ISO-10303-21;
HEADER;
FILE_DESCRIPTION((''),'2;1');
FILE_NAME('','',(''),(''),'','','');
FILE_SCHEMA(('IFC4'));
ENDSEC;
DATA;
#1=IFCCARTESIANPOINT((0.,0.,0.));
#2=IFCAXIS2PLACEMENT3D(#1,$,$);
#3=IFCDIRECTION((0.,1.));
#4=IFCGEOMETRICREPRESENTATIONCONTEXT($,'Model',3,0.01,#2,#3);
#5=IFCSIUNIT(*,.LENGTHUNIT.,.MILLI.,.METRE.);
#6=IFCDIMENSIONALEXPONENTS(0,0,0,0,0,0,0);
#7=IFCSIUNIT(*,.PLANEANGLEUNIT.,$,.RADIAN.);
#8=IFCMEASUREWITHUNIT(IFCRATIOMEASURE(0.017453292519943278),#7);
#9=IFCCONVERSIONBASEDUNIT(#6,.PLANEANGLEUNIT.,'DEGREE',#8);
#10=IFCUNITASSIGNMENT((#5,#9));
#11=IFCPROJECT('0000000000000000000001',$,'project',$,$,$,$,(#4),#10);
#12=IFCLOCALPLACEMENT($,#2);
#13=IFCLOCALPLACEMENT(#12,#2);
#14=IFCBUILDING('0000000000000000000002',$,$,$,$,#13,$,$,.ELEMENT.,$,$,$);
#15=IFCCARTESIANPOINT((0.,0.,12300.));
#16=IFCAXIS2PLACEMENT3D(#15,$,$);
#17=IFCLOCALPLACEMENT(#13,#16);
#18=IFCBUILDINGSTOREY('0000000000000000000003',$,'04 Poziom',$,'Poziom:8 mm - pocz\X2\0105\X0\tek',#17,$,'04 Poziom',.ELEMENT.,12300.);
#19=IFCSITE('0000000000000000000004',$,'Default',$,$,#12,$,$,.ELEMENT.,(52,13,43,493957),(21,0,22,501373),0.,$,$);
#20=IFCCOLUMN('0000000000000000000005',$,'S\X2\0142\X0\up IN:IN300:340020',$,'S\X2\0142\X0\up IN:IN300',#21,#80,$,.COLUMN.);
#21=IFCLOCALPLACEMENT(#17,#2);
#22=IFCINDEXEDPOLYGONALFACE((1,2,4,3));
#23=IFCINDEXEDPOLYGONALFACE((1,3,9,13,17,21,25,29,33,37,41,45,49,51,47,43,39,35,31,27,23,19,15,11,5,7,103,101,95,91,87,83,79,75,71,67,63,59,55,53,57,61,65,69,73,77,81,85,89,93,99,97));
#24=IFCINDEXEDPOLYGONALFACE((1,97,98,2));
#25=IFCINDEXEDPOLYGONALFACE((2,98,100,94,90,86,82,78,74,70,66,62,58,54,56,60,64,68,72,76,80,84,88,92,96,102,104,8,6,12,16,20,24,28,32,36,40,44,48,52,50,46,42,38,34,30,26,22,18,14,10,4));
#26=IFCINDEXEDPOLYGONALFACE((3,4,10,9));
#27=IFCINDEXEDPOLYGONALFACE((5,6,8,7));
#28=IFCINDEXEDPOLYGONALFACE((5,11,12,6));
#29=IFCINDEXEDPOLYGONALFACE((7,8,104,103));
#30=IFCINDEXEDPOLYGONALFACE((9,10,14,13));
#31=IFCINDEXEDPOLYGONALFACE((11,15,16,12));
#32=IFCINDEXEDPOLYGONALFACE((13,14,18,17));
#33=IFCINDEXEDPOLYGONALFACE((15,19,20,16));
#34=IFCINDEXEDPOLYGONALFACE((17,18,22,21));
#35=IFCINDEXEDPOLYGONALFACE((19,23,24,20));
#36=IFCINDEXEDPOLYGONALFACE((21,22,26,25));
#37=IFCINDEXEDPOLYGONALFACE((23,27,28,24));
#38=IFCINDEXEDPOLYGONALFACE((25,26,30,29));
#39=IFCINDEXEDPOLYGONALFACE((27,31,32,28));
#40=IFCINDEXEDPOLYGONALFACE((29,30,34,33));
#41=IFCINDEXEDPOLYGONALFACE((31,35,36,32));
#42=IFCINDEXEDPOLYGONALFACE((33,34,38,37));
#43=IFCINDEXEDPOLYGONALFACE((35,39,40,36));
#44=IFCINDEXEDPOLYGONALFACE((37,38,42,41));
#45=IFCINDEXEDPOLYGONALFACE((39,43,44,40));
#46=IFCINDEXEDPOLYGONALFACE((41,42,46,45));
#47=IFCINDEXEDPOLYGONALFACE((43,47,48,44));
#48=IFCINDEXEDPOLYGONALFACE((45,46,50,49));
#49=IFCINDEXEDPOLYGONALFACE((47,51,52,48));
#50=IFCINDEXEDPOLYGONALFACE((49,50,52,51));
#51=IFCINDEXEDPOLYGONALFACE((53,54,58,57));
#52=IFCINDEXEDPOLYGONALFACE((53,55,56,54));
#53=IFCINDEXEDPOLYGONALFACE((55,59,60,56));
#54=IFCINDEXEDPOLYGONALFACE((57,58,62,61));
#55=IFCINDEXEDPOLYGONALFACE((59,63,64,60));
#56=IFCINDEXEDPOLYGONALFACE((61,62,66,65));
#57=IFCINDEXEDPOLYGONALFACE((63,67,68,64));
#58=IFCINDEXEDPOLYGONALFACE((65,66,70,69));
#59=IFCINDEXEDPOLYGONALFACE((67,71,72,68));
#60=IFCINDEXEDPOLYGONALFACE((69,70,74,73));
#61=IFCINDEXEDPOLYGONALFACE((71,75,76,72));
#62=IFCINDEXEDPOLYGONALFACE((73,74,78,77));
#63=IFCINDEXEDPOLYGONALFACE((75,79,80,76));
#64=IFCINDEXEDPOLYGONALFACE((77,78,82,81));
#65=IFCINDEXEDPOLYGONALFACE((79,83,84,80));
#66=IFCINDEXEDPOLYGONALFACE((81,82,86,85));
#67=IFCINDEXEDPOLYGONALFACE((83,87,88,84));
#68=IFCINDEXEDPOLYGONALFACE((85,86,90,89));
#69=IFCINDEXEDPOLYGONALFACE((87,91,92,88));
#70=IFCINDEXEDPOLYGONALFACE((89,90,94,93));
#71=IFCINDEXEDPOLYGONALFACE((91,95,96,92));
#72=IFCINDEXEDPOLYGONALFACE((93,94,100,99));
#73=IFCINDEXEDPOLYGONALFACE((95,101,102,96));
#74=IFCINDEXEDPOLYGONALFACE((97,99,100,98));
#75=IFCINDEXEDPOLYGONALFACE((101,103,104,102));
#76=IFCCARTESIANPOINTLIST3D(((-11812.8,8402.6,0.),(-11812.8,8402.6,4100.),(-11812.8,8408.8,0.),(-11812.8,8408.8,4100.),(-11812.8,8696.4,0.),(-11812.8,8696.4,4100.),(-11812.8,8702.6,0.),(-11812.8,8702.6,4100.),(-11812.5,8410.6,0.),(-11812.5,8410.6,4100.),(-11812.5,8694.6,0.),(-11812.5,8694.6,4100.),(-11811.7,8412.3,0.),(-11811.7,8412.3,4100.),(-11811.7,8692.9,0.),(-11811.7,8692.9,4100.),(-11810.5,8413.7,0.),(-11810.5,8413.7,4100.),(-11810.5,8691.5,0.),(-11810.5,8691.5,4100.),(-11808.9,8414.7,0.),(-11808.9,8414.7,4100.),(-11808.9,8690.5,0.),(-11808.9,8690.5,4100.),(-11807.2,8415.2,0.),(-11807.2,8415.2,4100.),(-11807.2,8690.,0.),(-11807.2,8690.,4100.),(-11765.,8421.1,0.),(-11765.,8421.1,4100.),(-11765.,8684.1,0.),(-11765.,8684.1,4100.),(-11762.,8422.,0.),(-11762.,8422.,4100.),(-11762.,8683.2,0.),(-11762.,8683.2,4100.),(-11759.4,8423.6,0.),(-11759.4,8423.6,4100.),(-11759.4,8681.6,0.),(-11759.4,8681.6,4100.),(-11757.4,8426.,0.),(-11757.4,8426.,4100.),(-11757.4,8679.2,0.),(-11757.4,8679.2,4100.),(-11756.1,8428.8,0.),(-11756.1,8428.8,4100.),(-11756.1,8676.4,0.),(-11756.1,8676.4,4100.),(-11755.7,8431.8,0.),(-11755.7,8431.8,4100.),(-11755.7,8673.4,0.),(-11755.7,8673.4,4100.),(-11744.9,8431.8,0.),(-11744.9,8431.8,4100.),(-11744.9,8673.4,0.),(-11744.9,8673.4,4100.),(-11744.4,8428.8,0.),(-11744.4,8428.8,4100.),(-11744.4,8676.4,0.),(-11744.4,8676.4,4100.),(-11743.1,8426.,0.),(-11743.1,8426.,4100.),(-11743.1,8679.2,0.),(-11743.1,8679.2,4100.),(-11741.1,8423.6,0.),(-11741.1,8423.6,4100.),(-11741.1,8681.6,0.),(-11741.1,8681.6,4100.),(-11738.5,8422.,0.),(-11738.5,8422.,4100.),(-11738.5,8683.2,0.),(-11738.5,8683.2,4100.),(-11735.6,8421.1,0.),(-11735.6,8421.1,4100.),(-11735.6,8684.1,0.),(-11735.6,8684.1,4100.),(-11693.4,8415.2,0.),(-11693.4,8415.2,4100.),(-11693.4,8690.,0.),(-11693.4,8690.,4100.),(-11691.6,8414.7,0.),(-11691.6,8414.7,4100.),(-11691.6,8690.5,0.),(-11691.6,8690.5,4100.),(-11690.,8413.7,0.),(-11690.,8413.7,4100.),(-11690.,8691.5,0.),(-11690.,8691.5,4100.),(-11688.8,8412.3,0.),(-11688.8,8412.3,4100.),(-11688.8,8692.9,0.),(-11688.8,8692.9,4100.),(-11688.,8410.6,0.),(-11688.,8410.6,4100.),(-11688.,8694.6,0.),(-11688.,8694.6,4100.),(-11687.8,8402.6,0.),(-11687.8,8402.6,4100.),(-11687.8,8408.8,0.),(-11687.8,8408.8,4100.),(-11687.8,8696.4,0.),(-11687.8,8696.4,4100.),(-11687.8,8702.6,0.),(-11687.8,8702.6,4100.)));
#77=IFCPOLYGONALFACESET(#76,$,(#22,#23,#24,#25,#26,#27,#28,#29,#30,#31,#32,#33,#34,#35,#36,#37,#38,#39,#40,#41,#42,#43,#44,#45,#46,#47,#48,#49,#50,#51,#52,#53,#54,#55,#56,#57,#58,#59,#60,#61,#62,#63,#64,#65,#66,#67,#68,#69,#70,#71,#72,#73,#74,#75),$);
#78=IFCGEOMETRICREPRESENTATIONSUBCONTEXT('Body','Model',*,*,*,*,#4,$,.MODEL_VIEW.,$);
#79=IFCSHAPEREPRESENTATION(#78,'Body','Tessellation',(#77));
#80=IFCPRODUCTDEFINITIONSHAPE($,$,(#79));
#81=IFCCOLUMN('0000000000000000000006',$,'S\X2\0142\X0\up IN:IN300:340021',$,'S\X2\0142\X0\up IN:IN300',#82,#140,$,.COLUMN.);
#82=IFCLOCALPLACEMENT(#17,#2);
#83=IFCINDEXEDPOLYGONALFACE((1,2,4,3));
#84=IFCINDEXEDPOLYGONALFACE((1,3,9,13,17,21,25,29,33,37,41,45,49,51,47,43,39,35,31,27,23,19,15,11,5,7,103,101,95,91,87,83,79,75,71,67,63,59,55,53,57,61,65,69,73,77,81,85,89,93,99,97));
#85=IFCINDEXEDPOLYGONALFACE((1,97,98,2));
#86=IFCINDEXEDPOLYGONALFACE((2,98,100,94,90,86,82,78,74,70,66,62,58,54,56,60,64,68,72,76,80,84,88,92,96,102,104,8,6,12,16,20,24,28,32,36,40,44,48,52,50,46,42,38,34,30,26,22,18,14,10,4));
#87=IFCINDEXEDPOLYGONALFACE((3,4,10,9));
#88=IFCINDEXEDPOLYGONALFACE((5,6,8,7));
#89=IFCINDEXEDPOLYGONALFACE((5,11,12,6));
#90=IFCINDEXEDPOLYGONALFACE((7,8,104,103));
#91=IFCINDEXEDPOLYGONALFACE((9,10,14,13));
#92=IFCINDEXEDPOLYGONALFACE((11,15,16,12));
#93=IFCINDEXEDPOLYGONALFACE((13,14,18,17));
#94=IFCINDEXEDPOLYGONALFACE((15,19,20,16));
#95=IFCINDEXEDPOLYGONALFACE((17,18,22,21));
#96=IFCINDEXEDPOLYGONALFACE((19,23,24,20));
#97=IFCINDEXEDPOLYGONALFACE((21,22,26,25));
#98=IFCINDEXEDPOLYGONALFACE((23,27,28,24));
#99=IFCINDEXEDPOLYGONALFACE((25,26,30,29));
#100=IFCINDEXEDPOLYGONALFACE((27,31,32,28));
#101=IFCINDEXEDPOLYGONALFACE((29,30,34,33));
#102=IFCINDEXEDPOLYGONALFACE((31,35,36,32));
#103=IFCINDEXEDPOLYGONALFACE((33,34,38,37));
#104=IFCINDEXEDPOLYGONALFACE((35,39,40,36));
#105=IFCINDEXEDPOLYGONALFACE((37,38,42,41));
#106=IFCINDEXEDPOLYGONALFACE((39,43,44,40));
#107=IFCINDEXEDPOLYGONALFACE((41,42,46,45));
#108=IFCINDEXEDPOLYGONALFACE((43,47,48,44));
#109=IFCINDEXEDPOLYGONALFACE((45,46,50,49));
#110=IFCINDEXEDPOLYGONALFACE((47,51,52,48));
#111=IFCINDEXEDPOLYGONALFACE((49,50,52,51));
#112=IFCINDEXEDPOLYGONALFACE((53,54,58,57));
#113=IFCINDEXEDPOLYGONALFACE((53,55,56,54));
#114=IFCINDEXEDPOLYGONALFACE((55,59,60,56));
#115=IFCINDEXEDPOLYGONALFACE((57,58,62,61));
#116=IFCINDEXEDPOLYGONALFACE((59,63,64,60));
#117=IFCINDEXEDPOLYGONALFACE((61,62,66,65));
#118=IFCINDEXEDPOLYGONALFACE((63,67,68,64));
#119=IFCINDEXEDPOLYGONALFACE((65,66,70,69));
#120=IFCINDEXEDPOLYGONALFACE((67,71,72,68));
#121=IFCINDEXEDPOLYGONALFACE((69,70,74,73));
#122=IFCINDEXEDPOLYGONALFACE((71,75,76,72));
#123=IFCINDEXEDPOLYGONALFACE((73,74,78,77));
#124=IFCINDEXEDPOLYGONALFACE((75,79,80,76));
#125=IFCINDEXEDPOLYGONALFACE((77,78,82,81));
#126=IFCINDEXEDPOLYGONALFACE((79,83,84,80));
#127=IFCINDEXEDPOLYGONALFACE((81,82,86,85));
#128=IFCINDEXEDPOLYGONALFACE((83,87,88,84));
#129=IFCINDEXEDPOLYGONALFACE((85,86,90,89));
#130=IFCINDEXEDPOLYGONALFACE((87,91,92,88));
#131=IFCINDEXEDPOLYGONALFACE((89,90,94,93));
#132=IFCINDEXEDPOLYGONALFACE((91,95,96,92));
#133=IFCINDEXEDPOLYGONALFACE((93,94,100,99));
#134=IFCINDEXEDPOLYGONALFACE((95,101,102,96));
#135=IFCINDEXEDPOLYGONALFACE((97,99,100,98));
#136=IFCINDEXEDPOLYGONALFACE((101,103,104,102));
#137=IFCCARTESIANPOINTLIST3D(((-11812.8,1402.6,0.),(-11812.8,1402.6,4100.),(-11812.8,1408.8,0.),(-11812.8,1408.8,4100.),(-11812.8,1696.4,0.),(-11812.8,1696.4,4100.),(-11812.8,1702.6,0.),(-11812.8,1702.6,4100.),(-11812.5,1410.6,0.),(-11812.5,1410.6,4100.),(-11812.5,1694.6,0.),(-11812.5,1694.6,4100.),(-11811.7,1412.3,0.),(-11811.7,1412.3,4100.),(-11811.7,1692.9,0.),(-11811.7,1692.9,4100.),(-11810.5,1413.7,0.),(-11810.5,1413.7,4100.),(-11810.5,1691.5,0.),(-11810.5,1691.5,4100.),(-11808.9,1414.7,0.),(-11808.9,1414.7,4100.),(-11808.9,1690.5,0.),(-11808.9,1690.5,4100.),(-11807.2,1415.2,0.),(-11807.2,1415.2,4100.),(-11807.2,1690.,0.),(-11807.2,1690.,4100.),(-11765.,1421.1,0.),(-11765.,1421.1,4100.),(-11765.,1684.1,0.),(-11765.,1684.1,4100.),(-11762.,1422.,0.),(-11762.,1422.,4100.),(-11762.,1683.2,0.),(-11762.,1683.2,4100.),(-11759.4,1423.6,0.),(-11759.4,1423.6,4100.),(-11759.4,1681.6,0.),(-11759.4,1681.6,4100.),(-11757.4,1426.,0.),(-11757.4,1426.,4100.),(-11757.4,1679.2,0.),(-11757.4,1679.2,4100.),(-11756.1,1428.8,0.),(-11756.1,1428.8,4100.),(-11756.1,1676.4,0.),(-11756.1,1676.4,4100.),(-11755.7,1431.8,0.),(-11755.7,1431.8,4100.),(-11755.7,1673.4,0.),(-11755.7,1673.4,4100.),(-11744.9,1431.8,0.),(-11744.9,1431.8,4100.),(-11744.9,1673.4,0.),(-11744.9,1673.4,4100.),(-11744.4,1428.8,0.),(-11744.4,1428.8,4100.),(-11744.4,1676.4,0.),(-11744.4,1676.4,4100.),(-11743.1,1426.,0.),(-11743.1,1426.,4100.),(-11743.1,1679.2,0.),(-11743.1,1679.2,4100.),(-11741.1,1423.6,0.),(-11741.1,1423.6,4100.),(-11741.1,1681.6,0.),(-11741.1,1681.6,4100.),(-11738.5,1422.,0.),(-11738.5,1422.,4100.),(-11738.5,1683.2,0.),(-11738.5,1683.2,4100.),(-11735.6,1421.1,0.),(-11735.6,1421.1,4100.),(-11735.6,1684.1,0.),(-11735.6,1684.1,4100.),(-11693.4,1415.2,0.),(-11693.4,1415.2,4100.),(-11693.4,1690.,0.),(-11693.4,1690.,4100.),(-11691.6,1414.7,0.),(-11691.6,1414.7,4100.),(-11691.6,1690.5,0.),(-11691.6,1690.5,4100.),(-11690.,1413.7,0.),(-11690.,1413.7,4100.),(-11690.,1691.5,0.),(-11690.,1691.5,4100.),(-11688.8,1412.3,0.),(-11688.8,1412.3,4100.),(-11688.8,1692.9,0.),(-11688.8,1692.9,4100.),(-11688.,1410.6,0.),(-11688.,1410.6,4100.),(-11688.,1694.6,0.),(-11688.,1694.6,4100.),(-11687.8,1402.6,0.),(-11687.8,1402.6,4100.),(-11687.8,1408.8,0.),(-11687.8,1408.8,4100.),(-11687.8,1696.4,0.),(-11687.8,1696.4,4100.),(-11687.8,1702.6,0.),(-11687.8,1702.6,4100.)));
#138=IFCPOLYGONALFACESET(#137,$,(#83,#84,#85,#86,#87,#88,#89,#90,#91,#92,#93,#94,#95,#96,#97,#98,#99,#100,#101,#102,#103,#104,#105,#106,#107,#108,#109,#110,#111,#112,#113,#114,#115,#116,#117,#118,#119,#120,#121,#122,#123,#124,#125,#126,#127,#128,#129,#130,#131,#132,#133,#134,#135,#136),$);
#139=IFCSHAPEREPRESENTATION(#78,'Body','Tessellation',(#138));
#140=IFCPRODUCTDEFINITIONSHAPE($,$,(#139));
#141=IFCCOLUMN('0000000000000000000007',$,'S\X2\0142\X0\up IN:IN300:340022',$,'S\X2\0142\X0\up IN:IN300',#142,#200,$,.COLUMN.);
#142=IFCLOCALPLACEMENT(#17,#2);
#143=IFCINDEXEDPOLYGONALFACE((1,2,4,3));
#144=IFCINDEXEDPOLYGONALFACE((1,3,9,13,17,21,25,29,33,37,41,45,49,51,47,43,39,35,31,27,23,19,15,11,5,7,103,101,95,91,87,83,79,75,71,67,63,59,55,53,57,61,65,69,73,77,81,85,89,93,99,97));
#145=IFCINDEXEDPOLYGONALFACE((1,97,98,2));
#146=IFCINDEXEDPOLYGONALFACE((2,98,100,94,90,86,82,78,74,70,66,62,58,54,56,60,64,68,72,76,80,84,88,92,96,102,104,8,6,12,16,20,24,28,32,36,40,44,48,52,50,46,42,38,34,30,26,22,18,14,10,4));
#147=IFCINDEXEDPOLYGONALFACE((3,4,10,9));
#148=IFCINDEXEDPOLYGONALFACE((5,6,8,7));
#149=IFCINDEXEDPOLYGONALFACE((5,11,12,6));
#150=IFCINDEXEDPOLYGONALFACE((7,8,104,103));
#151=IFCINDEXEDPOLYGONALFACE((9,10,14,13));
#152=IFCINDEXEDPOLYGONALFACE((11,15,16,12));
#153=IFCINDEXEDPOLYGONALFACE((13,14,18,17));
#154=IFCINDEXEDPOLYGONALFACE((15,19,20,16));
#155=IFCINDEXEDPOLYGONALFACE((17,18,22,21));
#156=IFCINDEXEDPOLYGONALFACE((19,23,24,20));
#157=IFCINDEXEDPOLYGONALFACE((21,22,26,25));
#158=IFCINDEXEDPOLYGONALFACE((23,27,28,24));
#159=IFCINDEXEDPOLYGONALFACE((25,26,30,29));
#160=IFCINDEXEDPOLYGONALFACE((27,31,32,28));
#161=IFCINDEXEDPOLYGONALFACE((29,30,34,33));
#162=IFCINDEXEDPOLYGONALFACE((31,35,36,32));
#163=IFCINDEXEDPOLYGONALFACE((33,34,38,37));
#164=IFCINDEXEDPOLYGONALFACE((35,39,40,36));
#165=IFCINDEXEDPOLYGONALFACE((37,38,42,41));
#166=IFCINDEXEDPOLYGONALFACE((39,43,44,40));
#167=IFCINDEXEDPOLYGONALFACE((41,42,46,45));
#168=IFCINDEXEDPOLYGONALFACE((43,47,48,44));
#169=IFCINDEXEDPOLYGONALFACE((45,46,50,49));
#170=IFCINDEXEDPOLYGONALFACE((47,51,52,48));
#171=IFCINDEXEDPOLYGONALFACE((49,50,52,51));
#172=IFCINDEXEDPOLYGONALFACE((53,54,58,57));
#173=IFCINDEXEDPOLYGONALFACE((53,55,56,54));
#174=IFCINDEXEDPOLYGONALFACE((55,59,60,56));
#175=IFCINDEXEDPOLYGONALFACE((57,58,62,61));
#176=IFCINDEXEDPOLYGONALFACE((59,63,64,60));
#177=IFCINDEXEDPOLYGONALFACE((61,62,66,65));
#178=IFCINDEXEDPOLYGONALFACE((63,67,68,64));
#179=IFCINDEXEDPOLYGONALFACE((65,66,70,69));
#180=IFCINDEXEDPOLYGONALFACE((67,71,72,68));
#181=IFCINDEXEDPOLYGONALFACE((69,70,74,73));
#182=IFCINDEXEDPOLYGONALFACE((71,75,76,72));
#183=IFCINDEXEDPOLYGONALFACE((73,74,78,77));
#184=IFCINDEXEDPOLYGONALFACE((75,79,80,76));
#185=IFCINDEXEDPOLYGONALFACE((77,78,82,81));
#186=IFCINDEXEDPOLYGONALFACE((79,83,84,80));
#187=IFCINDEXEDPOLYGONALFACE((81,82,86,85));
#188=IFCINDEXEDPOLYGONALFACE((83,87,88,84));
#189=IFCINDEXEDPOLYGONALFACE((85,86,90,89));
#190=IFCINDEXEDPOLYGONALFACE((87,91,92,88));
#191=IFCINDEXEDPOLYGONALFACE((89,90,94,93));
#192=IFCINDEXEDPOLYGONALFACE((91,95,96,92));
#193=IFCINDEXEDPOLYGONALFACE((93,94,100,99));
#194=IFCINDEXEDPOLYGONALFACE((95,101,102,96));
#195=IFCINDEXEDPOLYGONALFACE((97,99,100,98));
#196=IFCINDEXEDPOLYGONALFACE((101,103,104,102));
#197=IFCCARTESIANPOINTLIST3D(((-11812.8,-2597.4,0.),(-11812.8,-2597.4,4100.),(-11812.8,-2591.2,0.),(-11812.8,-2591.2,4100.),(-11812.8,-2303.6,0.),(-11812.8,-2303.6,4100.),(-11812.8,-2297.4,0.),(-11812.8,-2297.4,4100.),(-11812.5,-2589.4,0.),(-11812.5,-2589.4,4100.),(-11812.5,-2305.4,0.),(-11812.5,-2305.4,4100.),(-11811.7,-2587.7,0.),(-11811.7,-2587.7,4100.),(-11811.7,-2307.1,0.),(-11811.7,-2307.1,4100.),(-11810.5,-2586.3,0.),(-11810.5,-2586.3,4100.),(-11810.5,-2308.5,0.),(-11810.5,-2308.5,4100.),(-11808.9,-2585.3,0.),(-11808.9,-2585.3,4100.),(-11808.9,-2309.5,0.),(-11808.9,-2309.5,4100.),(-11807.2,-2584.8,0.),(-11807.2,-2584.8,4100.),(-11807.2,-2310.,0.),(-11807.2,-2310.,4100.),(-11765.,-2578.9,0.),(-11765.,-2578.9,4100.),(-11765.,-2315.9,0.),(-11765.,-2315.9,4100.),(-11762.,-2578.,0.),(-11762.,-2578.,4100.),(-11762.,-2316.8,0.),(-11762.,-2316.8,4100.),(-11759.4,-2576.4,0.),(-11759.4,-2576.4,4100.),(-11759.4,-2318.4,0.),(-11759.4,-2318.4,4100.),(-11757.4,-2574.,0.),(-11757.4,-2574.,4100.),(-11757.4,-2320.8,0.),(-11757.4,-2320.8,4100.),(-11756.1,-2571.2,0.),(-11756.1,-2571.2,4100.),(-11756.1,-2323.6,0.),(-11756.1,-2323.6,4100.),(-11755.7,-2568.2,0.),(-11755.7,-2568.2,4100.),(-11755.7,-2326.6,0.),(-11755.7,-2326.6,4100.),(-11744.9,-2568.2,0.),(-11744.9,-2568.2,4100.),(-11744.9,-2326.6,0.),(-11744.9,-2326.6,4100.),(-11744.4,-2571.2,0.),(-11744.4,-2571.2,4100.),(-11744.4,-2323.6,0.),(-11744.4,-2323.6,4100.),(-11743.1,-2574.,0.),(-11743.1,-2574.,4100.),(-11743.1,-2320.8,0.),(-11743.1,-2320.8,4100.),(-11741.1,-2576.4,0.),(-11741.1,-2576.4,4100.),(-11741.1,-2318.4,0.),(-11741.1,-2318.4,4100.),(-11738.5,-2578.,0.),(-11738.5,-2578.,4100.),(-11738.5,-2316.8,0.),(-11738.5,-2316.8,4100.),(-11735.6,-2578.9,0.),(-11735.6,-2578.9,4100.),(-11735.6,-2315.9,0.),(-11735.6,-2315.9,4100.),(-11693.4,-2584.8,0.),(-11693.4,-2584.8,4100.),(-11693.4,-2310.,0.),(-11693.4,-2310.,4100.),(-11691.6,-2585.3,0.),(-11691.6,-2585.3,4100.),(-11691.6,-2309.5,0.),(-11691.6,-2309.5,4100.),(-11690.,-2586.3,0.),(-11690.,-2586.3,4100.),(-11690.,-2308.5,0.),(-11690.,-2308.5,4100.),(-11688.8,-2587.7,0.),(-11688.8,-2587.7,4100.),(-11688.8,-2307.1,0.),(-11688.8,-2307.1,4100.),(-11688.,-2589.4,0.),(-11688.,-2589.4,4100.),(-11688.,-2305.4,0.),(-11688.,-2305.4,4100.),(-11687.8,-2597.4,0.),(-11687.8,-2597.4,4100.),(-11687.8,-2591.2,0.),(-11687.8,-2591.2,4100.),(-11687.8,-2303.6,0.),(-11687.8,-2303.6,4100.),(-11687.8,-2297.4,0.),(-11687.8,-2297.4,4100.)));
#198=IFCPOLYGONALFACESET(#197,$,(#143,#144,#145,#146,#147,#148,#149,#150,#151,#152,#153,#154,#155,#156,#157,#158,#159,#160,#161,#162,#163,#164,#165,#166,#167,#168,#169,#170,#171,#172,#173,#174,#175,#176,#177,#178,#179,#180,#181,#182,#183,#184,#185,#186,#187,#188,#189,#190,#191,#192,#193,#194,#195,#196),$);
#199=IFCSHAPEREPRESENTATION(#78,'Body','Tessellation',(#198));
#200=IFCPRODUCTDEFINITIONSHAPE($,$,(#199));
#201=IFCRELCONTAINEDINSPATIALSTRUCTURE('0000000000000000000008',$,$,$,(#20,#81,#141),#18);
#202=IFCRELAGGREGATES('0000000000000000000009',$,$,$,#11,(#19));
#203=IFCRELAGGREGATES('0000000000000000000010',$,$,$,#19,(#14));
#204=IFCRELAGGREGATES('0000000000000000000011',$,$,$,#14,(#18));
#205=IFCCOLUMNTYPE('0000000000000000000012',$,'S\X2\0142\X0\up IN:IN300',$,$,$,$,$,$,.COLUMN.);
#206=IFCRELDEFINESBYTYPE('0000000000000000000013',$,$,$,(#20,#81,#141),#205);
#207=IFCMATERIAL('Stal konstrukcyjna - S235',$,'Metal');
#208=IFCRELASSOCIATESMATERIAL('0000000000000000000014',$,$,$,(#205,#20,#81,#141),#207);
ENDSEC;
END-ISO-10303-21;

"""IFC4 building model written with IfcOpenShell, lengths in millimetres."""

from ifc_helpers import new_model, entity, si_unit, converted_unit, direction, frame, origin, place, context, subcontext, project, spatial, line, arc, indexed_curve, outline, extrude, source, transform, mapped, material, type_object, type_shapes, element, save


model = new_model("IFC4")

# Units and contexts
model_context = context("Model", 3, precision=0.01, world=origin(), true_north=direction((0.0, 1.0)))
body_context = subcontext(model_context, "Body", "Model", "MODEL_VIEW")
ifc_project = project(units=[si_unit("LENGTHUNIT", "METRE", prefix="MILLI"), converted_unit("PLANEANGLEUNIT", "DEGREE", entity("IfcRatioMeasure", 0.017453292519943278), si_unit("PLANEANGLEUNIT", "RADIAN"), dimensions=[0, 0, 0, 0, 0, 0, 0])], contexts=[model_context])

# Site, building, storey
site_placement = place(None, origin())
site = spatial("IfcSite", under=ifc_project, at=site_placement, Name="Default", CompositionType="ELEMENT", RefLatitude=(52, 13, 43, 493957), RefLongitude=(21, 0, 22, 501373), RefElevation=0.0)
building_placement = place(site_placement, origin())
building = spatial("IfcBuilding", under=site, at=building_placement, CompositionType="ELEMENT")
storey_placement = place(building_placement, frame((0.0, 0.0, 12300.0)))
storey = spatial("IfcBuildingStorey", under=building, at=storey_placement, Name="04 Poziom", ObjectType="Poziom:8 mm - początek", LongName="04 Poziom", CompositionType="ELEMENT", Elevation=12300.0)

# Columns
ifc_material_1 = material(Name="Stal konstrukcyjna - S235", Category="Metal")
column_type = type_object("IfcColumnType", Name="Słup IN:IN300", PredefinedType="COLUMN", material=ifc_material_1)
shared_shape_1 = source(origin(), body_context, "Body", "SweptSolid", [
    extrude(outline(indexed_curve([(143.8, -62.5), (150.0, -62.5), (150.0, 62.5), (143.8, 62.5), (139.6, 60.9), (137.4, 56.9), (131.5, 14.7), (127.9, 8.1), (120.8, 5.4), (-120.8, 5.4), (-127.9, 8.1), (-131.5, 14.7), (-137.4, 56.9), (-139.6, 60.9), (-143.8, 62.5), (-150.0, 62.5), (-150.0, -62.5), (-143.8, -62.5), (-139.6, -60.9), (-137.4, -56.9), (-131.5, -14.7), (-127.9, -8.1), (-120.8, -5.4), (120.8, -5.4), (127.9, -8.1), (131.5, -14.7), (137.4, -56.9), (139.6, -60.9)], segments=[line(1, 2, 3, 4), arc(4, 5, 6), line(6, 7), arc(7, 8, 9), line(9, 10), arc(10, 11, 12), line(12, 13), arc(13, 14, 15), line(15, 16, 17, 18), arc(18, 19, 20), line(20, 21), arc(21, 22, 23), line(23, 24), arc(24, 25, 26), line(26, 27), arc(27, 28, 1)], self_intersect=False)), frame((0.0, 0.0, 12300.0), z_axis=(0.0, 0.0, 1.0), x_axis=(0.0, -1.0, 0.0)), (0.0, 0.0, 1.0), 4100.0),
])
type_shapes(column_type, [shared_shape_1])
for number, where, name in (
    (1, (-11750.3, 8552.6, -12300.0), "Słup IN:IN300:340020"),
    (2, (-11750.3, 1552.6, -12300.0), "Słup IN:IN300:340021"),
    (3, (-11750.3, -2447.4, -12300.0), "Słup IN:IN300:340022"),
):
    element("IfcColumn", number, at=place(storey_placement, frame(where)), inside=storey, type_object=column_type, material=ifc_material_1, Name=name, ObjectType="Słup IN:IN300", PredefinedType="COLUMN", context=body_context, shape_type="MappedRepresentation", body=[
        mapped(shared_shape_1, transform((0.0, 0.0, 0.0), scale=1.0)),
    ])

save(model, "model.ifc")
